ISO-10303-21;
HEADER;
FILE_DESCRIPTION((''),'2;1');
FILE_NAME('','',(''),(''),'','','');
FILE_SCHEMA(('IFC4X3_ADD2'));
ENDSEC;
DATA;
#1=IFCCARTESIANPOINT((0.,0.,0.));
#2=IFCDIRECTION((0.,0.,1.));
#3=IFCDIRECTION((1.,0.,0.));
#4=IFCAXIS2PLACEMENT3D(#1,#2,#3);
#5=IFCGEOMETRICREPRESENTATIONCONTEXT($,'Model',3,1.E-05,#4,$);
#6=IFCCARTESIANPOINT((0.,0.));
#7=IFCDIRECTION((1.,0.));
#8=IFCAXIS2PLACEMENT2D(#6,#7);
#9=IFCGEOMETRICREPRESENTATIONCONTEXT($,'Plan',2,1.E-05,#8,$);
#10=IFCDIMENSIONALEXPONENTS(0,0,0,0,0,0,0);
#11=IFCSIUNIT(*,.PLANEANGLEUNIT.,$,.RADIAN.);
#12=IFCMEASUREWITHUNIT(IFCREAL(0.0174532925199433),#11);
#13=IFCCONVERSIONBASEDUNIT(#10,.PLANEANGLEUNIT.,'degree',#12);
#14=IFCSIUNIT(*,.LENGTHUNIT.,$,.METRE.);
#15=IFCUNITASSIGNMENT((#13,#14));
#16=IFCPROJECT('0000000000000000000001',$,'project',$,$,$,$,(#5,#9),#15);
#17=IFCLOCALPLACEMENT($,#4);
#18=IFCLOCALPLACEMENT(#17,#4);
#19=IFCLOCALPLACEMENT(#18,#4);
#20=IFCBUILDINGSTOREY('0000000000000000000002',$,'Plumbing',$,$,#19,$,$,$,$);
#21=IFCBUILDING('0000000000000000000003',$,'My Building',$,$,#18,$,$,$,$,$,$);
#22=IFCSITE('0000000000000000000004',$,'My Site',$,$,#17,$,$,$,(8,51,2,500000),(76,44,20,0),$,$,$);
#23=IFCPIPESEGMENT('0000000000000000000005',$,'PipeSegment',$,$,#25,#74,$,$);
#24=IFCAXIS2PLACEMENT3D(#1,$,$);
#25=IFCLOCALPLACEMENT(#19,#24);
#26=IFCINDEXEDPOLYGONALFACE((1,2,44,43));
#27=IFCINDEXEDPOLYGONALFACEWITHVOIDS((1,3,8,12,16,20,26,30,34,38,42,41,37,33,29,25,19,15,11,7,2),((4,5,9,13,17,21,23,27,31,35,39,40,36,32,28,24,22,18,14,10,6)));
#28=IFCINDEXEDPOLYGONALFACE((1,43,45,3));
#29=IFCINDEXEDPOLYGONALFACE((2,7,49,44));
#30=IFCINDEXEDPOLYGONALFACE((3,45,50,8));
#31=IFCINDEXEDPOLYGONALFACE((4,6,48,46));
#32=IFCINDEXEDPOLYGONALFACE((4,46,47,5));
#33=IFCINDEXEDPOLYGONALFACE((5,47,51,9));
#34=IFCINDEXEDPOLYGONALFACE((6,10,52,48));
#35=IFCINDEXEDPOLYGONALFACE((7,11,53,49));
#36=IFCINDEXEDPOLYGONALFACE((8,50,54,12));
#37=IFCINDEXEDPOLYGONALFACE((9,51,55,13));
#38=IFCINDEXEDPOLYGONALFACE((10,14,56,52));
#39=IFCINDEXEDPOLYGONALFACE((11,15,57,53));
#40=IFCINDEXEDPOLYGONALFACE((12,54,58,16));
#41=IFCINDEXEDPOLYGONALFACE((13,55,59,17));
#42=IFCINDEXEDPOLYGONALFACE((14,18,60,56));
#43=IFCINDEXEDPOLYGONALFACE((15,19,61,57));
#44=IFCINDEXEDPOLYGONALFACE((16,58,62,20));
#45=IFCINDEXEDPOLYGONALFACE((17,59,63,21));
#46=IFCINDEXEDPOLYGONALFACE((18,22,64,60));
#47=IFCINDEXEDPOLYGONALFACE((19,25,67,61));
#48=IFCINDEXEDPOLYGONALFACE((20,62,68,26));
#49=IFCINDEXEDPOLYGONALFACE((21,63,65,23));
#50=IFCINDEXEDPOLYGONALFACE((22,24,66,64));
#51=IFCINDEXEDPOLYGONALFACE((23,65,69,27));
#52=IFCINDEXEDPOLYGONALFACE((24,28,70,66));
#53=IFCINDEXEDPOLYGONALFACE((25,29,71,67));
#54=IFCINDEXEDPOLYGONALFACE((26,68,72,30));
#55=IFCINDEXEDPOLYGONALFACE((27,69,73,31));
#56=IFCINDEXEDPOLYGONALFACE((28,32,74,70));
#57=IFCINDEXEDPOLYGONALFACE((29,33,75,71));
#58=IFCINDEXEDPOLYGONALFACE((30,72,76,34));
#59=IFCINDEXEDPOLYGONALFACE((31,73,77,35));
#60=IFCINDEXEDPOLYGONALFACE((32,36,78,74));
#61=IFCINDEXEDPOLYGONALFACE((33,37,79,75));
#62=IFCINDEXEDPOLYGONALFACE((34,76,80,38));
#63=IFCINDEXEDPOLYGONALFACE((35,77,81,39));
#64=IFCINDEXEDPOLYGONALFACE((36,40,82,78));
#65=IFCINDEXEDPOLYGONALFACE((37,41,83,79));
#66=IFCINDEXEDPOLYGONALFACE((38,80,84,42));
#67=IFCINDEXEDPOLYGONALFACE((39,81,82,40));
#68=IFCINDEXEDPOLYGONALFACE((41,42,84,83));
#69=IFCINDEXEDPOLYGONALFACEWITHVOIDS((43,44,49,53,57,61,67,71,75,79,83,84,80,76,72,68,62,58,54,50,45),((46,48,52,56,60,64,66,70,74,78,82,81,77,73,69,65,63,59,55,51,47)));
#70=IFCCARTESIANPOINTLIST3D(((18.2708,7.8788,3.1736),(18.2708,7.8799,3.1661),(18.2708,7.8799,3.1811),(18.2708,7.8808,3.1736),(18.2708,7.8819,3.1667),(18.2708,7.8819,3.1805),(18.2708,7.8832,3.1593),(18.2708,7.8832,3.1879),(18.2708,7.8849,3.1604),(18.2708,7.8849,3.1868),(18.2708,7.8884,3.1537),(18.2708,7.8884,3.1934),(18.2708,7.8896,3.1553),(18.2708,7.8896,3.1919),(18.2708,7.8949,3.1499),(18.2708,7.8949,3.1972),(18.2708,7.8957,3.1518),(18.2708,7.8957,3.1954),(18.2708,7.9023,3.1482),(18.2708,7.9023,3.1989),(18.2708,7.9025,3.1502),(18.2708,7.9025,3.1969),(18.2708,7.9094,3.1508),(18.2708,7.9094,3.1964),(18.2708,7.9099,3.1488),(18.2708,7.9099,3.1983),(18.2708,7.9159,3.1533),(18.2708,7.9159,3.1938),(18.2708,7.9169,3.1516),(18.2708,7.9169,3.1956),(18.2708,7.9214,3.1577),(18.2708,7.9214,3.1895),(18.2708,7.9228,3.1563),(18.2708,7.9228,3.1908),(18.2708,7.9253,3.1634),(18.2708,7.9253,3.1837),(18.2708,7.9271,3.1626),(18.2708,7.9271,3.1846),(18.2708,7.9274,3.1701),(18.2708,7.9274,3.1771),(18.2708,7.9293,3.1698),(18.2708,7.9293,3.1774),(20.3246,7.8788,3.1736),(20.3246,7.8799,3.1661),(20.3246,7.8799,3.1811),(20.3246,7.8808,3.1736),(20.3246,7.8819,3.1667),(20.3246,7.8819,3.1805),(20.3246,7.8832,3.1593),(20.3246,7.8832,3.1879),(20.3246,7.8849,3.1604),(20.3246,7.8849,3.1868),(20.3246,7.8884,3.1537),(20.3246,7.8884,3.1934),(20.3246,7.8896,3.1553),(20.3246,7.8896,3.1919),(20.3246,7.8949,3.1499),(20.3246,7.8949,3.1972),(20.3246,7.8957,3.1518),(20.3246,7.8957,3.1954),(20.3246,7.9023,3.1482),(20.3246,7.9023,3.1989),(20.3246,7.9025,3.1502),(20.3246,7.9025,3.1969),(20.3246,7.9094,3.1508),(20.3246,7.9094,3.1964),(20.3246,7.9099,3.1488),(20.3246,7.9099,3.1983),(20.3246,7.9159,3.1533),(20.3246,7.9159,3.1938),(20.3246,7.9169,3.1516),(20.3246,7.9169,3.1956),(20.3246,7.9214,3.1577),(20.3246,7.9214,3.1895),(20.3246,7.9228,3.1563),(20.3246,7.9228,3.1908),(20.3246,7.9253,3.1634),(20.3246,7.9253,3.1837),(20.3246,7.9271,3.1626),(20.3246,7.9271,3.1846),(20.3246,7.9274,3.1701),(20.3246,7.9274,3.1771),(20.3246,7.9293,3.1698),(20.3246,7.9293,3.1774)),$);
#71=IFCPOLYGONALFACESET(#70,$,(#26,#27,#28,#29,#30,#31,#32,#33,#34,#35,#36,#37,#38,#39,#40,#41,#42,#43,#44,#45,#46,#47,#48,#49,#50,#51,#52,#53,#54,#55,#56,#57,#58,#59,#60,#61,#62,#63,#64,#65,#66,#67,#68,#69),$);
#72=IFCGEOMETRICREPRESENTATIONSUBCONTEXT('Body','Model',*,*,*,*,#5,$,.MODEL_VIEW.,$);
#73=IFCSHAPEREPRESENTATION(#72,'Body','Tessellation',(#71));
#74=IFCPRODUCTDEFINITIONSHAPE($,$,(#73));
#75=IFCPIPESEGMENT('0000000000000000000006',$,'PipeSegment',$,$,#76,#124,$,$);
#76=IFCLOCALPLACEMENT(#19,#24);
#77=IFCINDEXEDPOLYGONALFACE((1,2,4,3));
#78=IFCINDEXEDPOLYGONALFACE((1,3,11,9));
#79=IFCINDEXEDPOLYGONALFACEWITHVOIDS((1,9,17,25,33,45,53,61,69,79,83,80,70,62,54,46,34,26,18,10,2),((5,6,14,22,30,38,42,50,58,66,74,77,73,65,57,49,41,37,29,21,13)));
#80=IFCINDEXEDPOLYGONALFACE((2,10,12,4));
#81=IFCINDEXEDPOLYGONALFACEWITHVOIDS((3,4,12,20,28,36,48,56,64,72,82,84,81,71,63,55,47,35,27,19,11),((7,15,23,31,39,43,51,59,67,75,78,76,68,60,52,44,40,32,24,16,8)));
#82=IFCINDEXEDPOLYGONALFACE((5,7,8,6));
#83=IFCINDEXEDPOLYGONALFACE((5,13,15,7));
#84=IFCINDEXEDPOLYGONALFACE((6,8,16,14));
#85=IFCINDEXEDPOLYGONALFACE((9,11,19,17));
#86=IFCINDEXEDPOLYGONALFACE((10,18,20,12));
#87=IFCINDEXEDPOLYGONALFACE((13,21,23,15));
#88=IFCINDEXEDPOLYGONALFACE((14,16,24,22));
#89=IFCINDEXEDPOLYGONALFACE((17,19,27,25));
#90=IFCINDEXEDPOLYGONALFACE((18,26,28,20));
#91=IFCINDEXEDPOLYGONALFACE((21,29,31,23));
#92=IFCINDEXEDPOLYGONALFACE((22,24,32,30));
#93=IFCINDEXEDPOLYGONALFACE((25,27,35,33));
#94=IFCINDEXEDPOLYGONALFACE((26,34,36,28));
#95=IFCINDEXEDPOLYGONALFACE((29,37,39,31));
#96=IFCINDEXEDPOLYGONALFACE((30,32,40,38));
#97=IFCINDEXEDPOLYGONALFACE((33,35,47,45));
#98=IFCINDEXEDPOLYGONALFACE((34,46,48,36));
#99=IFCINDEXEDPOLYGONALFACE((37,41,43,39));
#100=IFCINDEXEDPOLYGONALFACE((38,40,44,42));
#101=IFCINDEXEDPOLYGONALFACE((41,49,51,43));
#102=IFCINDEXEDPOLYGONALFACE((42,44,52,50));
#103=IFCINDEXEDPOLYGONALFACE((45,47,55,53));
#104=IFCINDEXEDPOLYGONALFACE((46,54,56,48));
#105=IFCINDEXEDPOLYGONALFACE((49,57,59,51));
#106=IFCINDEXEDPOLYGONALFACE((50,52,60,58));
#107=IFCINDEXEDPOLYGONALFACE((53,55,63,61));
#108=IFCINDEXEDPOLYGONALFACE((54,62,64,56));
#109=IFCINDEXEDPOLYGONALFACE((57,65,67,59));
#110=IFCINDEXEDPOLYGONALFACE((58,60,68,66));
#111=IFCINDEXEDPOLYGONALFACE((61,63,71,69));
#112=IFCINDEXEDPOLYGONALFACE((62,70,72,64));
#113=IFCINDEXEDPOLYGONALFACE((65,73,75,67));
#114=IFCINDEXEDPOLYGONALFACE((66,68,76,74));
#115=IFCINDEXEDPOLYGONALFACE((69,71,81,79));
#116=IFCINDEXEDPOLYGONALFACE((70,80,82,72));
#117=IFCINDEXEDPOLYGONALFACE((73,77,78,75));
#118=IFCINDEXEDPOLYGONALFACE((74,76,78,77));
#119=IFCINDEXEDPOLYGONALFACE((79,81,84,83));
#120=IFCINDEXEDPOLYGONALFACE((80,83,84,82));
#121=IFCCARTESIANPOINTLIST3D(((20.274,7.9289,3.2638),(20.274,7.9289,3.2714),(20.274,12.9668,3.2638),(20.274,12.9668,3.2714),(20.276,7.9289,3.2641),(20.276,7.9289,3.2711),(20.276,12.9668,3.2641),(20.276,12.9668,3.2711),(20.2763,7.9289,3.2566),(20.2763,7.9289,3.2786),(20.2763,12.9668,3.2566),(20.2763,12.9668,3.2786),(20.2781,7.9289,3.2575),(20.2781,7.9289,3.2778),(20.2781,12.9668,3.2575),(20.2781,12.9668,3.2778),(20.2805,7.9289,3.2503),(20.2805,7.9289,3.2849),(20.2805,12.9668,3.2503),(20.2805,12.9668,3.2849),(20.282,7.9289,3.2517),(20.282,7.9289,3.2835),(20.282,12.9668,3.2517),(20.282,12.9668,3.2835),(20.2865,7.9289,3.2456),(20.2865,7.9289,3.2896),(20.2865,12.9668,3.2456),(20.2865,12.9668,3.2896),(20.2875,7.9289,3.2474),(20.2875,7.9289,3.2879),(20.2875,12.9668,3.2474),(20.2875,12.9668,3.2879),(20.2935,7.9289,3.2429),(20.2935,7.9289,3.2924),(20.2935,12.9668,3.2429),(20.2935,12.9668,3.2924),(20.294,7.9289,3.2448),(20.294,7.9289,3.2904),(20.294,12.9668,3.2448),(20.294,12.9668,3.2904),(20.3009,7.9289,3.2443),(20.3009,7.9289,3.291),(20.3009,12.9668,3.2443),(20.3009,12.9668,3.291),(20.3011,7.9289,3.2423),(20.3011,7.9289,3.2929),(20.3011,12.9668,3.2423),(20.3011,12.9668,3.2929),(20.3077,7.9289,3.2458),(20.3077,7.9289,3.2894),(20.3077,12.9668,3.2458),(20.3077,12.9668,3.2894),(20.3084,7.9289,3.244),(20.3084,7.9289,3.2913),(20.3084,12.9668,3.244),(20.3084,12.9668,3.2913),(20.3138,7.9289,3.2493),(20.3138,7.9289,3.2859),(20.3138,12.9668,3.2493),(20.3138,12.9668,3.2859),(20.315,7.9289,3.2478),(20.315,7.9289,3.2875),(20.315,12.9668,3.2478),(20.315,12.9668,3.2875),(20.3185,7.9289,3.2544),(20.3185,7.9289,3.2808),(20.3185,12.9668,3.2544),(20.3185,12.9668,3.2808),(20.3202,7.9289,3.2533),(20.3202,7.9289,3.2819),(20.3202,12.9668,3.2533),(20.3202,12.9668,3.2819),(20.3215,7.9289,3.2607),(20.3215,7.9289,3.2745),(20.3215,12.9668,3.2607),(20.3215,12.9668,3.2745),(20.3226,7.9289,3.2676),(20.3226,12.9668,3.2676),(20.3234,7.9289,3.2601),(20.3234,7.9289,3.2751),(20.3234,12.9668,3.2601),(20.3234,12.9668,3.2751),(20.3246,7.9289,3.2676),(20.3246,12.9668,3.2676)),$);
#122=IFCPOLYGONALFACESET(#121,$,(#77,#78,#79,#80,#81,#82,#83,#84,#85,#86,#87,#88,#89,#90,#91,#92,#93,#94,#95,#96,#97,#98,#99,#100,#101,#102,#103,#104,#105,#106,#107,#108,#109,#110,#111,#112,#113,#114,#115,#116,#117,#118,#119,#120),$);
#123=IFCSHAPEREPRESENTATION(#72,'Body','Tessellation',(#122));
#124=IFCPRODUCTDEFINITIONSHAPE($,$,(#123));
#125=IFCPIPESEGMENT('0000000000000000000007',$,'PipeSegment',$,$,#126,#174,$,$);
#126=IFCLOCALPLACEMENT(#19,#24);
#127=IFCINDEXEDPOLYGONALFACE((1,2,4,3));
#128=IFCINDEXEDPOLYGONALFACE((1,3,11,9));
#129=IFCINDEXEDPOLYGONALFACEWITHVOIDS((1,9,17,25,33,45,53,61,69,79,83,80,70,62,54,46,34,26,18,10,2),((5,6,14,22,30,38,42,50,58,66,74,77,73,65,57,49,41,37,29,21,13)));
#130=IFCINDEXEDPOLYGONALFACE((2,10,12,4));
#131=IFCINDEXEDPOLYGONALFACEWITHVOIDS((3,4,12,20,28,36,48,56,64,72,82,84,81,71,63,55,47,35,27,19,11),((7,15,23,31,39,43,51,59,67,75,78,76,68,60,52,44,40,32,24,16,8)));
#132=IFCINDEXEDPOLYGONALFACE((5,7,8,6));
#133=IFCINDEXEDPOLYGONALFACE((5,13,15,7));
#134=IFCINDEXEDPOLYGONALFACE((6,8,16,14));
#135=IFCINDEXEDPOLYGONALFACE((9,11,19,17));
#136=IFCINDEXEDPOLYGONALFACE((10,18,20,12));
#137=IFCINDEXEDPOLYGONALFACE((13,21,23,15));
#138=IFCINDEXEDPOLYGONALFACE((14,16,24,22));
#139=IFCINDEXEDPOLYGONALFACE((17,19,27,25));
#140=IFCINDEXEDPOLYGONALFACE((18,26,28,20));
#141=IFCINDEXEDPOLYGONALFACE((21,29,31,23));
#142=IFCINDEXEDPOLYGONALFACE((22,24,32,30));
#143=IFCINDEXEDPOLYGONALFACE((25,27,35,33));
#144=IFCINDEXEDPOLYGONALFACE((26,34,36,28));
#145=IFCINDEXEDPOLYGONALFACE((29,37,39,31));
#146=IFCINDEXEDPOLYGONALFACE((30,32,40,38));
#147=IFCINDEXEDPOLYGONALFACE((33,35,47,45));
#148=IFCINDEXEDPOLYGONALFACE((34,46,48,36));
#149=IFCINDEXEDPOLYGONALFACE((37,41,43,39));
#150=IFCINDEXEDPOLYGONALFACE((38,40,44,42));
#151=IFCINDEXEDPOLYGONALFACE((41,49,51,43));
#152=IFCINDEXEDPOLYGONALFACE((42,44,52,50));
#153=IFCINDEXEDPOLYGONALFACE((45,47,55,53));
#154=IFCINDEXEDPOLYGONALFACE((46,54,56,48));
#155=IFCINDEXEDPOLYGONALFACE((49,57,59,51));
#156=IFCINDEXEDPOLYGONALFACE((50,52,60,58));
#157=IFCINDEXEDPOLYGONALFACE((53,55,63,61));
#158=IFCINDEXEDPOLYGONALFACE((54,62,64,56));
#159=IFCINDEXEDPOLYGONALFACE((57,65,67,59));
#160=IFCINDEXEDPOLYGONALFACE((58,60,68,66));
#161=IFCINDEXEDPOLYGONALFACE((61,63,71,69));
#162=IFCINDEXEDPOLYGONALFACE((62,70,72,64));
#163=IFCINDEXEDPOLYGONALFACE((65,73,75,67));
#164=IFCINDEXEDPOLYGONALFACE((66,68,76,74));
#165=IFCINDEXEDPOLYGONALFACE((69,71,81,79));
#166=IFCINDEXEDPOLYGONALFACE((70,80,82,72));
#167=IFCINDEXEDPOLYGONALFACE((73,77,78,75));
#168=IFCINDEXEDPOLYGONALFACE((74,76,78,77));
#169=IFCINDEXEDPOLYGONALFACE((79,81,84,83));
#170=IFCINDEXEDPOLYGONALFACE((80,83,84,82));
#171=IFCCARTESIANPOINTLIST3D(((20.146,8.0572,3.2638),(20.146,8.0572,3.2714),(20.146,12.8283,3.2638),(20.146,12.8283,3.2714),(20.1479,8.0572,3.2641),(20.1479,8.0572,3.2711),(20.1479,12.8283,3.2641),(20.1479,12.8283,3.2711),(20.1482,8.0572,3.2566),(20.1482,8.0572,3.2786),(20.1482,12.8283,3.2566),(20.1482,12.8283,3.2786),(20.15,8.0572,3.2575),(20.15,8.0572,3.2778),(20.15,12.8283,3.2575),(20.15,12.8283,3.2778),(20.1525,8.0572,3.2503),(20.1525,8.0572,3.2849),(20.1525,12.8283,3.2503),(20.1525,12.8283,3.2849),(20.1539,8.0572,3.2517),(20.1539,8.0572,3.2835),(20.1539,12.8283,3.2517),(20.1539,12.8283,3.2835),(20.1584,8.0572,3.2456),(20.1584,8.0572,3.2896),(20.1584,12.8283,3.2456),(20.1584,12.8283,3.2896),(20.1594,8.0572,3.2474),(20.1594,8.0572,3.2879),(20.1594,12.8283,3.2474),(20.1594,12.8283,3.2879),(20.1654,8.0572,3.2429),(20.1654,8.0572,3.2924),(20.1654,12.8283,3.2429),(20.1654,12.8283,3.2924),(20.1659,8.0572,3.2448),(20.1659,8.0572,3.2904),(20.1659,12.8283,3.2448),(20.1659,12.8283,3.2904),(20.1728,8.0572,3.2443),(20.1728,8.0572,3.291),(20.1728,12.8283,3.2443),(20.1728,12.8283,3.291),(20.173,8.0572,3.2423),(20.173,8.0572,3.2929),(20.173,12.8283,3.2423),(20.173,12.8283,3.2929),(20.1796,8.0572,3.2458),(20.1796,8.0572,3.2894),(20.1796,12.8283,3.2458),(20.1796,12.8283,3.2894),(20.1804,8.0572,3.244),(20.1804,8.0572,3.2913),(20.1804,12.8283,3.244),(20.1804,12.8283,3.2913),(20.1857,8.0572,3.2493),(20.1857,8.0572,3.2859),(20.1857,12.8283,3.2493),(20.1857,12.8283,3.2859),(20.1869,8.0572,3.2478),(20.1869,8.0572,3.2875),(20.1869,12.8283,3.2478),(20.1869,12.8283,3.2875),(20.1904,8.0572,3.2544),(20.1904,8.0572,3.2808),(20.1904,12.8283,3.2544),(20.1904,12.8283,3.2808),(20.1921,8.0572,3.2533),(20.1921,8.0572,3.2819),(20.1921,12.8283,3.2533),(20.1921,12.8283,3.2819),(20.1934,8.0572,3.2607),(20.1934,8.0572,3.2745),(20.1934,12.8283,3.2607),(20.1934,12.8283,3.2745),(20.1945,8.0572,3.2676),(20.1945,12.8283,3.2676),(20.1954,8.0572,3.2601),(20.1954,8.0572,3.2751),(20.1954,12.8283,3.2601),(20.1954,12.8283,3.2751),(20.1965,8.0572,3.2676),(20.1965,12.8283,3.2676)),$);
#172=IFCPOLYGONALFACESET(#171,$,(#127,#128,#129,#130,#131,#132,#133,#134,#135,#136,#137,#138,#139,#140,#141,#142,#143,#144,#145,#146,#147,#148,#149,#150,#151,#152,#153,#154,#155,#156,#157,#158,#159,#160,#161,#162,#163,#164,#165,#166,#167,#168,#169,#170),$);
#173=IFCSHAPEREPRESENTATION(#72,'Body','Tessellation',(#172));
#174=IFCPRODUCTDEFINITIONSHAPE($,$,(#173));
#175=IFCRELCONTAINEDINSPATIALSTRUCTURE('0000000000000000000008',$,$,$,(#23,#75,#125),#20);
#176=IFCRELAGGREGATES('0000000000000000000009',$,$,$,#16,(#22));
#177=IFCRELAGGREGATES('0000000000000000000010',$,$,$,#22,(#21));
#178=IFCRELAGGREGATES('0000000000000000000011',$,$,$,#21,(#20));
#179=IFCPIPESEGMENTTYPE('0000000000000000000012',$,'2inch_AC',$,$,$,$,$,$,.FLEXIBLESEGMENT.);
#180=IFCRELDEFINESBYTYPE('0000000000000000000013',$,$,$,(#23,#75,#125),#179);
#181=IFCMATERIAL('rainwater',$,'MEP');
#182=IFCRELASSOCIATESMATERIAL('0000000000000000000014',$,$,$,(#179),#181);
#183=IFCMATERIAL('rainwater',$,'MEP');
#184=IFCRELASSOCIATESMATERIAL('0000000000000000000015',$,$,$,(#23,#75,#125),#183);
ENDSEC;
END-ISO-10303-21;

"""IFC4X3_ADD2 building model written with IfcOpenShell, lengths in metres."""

from ifc_helpers import new_model, entity, si_unit, converted_unit, frame, origin_with_axes, origin_2d_with_axis, place, context, subcontext, project, spatial, hollow_circle, extrude, material, material_profile, profile_set, profile_usage, type_object, element, save


model = new_model("IFC4X3_ADD2")

# Units and contexts
model_context = context("Model", 3, precision=1e-05, world=origin_with_axes())
plan_context = context("Plan", 2, precision=1e-05, world=origin_2d_with_axis())
body_context = subcontext(model_context, "Body", "Model", "MODEL_VIEW")
ifc_project = project(units=[converted_unit("PLANEANGLEUNIT", "degree", entity("IfcReal", 0.0174532925199433), si_unit("PLANEANGLEUNIT", "RADIAN"), dimensions=[0, 0, 0, 0, 0, 0, 0]), si_unit("LENGTHUNIT", "METRE")], contexts=[model_context, plan_context])

# Site, building, storey
site_placement = place(None, origin_with_axes())
site = spatial("IfcSite", under=ifc_project, at=site_placement, Name="My Site", RefLatitude=(8, 51, 2, 500000), RefLongitude=(76, 44, 20, 0))
building_placement = place(site_placement, origin_with_axes())
building = spatial("IfcBuilding", under=site, at=building_placement, Name="My Building")
storey_placement = place(building_placement, origin_with_axes())
storey = spatial("IfcBuildingStorey", under=building, at=storey_placement, Name="Plumbing")

# Pipe segments
ifc_material_1 = material(Name="rainwater", Category="MEP")
ifc_material_2 = material(Name="rainwater", Category="MEP")
ifc_material_profile_1 = material_profile(ifc_material_2, hollow_circle(Radius=0.0254, WallThickness=0.002))
ifc_profile_set_1 = profile_set([ifc_material_profile_1], Name="water")
ifc_material_profile_2 = material_profile(ifc_material_1, hollow_circle(Radius=0.0254, WallThickness=0.002))
ifc_profile_set_2 = profile_set([ifc_material_profile_2], Name="water")
pipe_segment_type_1 = type_object("IfcPipeSegmentType", Name="2inch_AC", PredefinedType="FLEXIBLESEGMENT", material=ifc_profile_set_2)
ifc_profile_usage_1 = profile_usage(ifc_profile_set_1, cardinal=5)
pipe_segment_1_placement = place(storey_placement, frame((20.3246, 7.9042, 3.1736), z_axis=(-1.0, 0.0, 0.0), x_axis=(0.0, -1.0, 0.0)))
element("IfcPipeSegment", 1, at=pipe_segment_1_placement, inside=storey, type_object=pipe_segment_type_1, material=ifc_profile_usage_1, Name="PipeSegment", context=body_context, shape_type="SweptSolid", body=[
    extrude(hollow_circle(Radius=0.0254, WallThickness=0.002), origin_with_axes(), (0.0, 0.0, 1.0), 2.0537),
])
ifc_profile_usage_2 = profile_usage(ifc_profile_set_1, cardinal=5)
pipe_segment_2_placement = place(storey_placement, frame((20.2992, 12.9668, 3.2676), z_axis=(0.0, -1.0, 0.0), x_axis=(1.0, 0.0, 0.0)))
element("IfcPipeSegment", 2, at=pipe_segment_2_placement, inside=storey, type_object=pipe_segment_type_1, material=ifc_profile_usage_2, Name="PipeSegment", context=body_context, shape_type="SweptSolid", body=[
    extrude(hollow_circle(Radius=0.0254, WallThickness=0.002), origin_with_axes(), (0.0, 0.0, 1.0), 5.0379),
])
ifc_profile_usage_3 = profile_usage(ifc_profile_set_1, cardinal=5)
pipe_segment_3_placement = place(storey_placement, frame((20.1711, 12.8283, 3.2676), z_axis=(0.0, -1.0, 0.0), x_axis=(1.0, 0.0, 0.0)))
element("IfcPipeSegment", 3, at=pipe_segment_3_placement, inside=storey, type_object=pipe_segment_type_1, material=ifc_profile_usage_3, Name="PipeSegment", context=body_context, shape_type="SweptSolid", body=[
    extrude(hollow_circle(Radius=0.0254, WallThickness=0.002), origin_with_axes(), (0.0, 0.0, 1.0), 4.7711),
])

save(model, "model.ifc")
